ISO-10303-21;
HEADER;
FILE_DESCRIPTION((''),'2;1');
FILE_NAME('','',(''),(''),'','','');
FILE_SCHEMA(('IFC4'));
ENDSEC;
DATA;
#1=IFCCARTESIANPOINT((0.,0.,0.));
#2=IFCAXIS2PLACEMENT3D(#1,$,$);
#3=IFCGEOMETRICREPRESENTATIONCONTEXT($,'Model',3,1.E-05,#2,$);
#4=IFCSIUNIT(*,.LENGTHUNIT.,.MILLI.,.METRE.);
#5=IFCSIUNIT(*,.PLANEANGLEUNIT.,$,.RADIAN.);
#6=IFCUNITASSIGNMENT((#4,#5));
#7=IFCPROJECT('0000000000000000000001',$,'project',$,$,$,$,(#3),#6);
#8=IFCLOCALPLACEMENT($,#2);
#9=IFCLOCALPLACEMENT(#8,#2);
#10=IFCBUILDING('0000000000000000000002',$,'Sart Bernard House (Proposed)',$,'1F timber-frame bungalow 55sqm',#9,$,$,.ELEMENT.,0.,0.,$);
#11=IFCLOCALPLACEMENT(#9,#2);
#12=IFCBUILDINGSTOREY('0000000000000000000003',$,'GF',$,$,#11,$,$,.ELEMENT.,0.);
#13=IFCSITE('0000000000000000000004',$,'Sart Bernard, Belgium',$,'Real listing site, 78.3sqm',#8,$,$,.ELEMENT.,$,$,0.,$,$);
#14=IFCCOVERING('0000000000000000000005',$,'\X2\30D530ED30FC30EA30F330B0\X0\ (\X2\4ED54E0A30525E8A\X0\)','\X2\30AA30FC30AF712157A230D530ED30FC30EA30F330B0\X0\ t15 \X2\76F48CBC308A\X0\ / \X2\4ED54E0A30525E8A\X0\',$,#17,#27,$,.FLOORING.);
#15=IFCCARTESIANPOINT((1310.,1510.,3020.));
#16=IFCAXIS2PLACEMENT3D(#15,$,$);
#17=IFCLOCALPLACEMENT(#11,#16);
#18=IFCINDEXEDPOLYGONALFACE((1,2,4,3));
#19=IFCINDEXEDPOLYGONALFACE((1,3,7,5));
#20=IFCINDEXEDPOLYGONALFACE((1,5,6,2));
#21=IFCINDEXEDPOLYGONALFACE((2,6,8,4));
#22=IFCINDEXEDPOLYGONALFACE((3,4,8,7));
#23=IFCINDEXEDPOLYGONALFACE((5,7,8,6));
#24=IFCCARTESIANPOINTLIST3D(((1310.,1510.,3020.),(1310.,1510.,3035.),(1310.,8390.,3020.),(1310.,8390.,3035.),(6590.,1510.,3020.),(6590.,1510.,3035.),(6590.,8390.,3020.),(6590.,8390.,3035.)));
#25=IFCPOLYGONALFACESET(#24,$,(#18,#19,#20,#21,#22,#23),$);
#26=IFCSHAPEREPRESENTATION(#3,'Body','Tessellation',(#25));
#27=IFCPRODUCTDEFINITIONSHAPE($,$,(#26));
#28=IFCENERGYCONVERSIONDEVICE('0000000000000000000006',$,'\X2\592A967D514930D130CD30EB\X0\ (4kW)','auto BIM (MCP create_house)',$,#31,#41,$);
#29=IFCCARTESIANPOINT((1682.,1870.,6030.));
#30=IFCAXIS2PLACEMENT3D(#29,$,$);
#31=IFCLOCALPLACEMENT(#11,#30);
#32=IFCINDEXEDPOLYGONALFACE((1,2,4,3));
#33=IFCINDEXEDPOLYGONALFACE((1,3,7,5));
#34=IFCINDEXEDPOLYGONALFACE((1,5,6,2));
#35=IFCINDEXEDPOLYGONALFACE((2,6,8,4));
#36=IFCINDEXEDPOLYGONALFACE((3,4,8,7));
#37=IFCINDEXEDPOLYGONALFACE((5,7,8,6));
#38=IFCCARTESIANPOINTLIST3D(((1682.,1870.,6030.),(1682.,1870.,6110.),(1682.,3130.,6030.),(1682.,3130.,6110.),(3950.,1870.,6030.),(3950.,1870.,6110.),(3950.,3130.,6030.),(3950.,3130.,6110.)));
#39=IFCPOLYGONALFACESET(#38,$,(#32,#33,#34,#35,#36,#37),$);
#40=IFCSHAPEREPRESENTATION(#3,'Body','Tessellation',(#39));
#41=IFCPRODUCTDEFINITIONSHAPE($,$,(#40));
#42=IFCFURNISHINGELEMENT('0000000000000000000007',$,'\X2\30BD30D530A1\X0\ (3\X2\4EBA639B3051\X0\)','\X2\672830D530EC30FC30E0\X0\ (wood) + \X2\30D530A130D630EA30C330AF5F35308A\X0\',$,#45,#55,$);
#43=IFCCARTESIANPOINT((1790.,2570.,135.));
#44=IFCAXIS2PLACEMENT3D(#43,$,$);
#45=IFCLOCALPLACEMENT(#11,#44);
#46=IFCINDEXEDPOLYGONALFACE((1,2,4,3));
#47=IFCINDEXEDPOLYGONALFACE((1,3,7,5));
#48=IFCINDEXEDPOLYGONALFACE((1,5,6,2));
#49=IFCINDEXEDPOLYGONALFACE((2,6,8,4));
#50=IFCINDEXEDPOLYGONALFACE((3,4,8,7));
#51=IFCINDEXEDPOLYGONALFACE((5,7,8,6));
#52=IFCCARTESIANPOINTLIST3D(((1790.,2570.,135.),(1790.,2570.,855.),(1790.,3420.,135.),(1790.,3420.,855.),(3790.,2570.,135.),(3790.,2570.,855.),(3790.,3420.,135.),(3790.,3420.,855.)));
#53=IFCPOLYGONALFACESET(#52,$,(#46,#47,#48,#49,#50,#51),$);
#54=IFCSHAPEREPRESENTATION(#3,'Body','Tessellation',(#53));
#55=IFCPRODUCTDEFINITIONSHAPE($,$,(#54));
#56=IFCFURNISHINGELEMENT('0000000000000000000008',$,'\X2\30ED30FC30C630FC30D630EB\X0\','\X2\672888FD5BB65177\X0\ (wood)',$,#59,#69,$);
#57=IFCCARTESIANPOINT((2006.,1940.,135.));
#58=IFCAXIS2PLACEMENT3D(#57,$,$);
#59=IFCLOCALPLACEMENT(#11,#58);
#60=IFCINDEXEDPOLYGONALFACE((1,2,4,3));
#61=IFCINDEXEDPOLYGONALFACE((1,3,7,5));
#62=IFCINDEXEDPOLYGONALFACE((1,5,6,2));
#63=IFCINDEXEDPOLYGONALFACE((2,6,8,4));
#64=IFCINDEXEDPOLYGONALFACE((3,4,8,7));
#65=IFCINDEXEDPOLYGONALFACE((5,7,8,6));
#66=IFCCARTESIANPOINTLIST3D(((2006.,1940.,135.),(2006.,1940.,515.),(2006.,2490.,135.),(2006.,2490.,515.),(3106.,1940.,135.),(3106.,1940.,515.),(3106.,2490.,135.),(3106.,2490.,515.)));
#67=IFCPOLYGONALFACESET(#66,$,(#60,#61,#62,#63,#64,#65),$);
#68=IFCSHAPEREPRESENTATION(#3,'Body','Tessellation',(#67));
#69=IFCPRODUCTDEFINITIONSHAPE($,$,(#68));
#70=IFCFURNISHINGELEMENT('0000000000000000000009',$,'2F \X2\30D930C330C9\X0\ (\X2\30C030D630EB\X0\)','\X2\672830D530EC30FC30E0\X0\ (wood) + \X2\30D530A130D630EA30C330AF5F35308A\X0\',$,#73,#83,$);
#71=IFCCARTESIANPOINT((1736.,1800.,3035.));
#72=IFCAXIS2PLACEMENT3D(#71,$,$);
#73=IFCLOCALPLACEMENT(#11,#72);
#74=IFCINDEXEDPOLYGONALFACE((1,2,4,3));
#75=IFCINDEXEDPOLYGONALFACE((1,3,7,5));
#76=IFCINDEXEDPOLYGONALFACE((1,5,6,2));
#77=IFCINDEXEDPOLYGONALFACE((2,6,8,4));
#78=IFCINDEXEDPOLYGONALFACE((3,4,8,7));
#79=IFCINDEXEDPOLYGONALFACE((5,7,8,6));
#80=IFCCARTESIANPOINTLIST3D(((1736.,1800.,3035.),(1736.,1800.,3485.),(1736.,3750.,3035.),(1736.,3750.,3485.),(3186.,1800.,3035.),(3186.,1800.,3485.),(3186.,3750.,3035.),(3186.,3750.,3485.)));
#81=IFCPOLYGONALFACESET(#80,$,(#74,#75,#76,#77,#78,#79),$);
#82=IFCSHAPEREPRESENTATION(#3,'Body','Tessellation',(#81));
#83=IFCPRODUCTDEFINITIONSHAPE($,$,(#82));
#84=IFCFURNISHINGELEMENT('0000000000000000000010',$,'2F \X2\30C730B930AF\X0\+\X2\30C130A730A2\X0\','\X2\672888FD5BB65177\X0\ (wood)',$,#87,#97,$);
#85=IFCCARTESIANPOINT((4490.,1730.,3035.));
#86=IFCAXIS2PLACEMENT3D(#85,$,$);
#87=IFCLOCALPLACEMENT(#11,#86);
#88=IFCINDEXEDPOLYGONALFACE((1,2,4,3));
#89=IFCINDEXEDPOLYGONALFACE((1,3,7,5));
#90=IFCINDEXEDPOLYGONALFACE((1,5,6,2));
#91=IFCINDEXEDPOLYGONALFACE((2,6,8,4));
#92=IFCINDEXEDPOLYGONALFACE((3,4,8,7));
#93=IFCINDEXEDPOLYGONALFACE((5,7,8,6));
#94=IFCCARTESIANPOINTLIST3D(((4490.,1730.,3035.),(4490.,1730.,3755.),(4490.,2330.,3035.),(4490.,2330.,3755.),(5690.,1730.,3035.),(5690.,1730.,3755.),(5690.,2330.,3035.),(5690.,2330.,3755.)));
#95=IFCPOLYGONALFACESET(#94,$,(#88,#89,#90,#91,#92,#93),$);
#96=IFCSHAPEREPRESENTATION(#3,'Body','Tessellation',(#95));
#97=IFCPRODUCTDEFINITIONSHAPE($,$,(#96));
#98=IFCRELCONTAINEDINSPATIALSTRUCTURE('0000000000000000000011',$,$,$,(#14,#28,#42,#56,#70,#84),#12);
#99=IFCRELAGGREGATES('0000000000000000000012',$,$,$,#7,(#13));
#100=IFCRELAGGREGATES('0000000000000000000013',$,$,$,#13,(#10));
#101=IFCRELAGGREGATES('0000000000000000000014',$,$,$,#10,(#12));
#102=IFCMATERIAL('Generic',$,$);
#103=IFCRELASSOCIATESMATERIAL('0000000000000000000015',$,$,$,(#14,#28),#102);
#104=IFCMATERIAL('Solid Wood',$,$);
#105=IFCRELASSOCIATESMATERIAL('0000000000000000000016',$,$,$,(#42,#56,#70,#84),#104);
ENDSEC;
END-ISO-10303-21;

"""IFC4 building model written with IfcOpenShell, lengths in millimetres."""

from ifc_helpers import new_model, si_unit, frame, frame_2d, origin, place, context, project, spatial, rectangle, extrude, material, element, save


model = new_model("IFC4")

# Units and contexts
model_context = context("Model", 3, precision=1e-05, world=origin())
ifc_project = project(units=[si_unit("LENGTHUNIT", "METRE", prefix="MILLI"), si_unit("PLANEANGLEUNIT", "RADIAN")], contexts=[model_context])

# Site, building, storey
site_placement = place(None, origin())
site = spatial("IfcSite", under=ifc_project, at=site_placement, Name="Sart Bernard, Belgium", ObjectType="Real listing site, 78.3sqm", CompositionType="ELEMENT", RefElevation=0.0)
building_placement = place(site_placement, origin())
building = spatial("IfcBuilding", under=site, at=building_placement, Name="Sart Bernard House (Proposed)", ObjectType="1F timber-frame bungalow 55sqm", CompositionType="ELEMENT", ElevationOfRefHeight=0.0, ElevationOfTerrain=0.0)
storey_placement = place(building_placement, origin())
storey = spatial("IfcBuildingStorey", under=building, at=storey_placement, Name="GF", CompositionType="ELEMENT", Elevation=0.0)

# Shared definitions
ifc_material_1 = material(Name="Solid Wood")

# Shared definitions
ifc_material_2 = material(Name="Generic")

# Covering
covering_placement = place(storey_placement, frame((1310.0, 1510.0, 3020.0)))
element("IfcCovering", 1, at=covering_placement, inside=storey, material=ifc_material_2, Name="フローリング (仕上げ床)", Description="オーク無垢フローリング t15 直貼り / 仕上げ床", PredefinedType="FLOORING", context=model_context, shape_type="SweptSolid", body=[
    extrude(rectangle(XDim=5280.0, YDim=6880.0, at=frame_2d((2640.0, 3440.0))), frame((1310.0, 1510.0, 3020.0)), (0.0, 0.0, 1.0), 15.0),
])

# Energy conversion device
energy_conversion_device_placement = place(storey_placement, frame((1682.0, 1870.0, 6030.0)))
element("IfcEnergyConversionDevice", 2, at=energy_conversion_device_placement, inside=storey, material=ifc_material_2, Name="太陽光パネル (4kW)", Description="auto BIM (MCP create_house)", context=model_context, shape_type="SweptSolid", body=[
    extrude(rectangle(XDim=2268.0, YDim=1260.0, at=frame_2d((1134.0, 630.0))), frame((1682.0, 1870.0, 6030.0)), (0.0, 0.0, 1.0), 80.0),
])

# Furnishing elements
furnishing_1_placement = place(storey_placement, frame((1790.0, 2570.0, 135.0)))
element("IfcFurnishingElement", 3, at=furnishing_1_placement, inside=storey, material=ifc_material_1, Name="ソファ (3人掛け)", Description="木フレーム (wood) + ファブリック張り", context=model_context, shape_type="SweptSolid", body=[
    extrude(rectangle(XDim=2000.0, YDim=850.0, at=frame_2d((1000.0, 425.0))), frame((1790.0, 2570.0, 135.0)), (0.0, 0.0, 1.0), 720.0),
])
furnishing_2_placement = place(storey_placement, frame((2006.0, 1940.0, 135.0)))
element("IfcFurnishingElement", 4, at=furnishing_2_placement, inside=storey, material=ifc_material_1, Name="ローテーブル", Description="木製家具 (wood)", context=model_context, shape_type="SweptSolid", body=[
    extrude(rectangle(XDim=1100.0, YDim=550.0, at=frame_2d((550.0, 275.0))), frame((2006.0, 1940.0, 135.0)), (0.0, 0.0, 1.0), 380.0),
])
furnishing_3_placement = place(storey_placement, frame((1736.0, 1800.0, 3035.0)))
element("IfcFurnishingElement", 5, at=furnishing_3_placement, inside=storey, material=ifc_material_1, Name="2F ベッド (ダブル)", Description="木フレーム (wood) + ファブリック張り", context=model_context, shape_type="SweptSolid", body=[
    extrude(rectangle(XDim=1450.0, YDim=1950.0, at=frame_2d((725.0, 975.0))), frame((1736.0, 1800.0, 3035.0)), (0.0, 0.0, 1.0), 450.0),
])
furnishing_4_placement = place(storey_placement, frame((4490.0, 1730.0, 3035.0)))
element("IfcFurnishingElement", 6, at=furnishing_4_placement, inside=storey, material=ifc_material_1, Name="2F デスク+チェア", Description="木製家具 (wood)", context=model_context, shape_type="SweptSolid", body=[
    extrude(rectangle(XDim=1200.0, YDim=600.0, at=frame_2d((600.0, 300.0))), frame((4490.0, 1730.0, 3035.0)), (0.0, 0.0, 1.0), 720.0),
])

save(model, "model.ifc")
